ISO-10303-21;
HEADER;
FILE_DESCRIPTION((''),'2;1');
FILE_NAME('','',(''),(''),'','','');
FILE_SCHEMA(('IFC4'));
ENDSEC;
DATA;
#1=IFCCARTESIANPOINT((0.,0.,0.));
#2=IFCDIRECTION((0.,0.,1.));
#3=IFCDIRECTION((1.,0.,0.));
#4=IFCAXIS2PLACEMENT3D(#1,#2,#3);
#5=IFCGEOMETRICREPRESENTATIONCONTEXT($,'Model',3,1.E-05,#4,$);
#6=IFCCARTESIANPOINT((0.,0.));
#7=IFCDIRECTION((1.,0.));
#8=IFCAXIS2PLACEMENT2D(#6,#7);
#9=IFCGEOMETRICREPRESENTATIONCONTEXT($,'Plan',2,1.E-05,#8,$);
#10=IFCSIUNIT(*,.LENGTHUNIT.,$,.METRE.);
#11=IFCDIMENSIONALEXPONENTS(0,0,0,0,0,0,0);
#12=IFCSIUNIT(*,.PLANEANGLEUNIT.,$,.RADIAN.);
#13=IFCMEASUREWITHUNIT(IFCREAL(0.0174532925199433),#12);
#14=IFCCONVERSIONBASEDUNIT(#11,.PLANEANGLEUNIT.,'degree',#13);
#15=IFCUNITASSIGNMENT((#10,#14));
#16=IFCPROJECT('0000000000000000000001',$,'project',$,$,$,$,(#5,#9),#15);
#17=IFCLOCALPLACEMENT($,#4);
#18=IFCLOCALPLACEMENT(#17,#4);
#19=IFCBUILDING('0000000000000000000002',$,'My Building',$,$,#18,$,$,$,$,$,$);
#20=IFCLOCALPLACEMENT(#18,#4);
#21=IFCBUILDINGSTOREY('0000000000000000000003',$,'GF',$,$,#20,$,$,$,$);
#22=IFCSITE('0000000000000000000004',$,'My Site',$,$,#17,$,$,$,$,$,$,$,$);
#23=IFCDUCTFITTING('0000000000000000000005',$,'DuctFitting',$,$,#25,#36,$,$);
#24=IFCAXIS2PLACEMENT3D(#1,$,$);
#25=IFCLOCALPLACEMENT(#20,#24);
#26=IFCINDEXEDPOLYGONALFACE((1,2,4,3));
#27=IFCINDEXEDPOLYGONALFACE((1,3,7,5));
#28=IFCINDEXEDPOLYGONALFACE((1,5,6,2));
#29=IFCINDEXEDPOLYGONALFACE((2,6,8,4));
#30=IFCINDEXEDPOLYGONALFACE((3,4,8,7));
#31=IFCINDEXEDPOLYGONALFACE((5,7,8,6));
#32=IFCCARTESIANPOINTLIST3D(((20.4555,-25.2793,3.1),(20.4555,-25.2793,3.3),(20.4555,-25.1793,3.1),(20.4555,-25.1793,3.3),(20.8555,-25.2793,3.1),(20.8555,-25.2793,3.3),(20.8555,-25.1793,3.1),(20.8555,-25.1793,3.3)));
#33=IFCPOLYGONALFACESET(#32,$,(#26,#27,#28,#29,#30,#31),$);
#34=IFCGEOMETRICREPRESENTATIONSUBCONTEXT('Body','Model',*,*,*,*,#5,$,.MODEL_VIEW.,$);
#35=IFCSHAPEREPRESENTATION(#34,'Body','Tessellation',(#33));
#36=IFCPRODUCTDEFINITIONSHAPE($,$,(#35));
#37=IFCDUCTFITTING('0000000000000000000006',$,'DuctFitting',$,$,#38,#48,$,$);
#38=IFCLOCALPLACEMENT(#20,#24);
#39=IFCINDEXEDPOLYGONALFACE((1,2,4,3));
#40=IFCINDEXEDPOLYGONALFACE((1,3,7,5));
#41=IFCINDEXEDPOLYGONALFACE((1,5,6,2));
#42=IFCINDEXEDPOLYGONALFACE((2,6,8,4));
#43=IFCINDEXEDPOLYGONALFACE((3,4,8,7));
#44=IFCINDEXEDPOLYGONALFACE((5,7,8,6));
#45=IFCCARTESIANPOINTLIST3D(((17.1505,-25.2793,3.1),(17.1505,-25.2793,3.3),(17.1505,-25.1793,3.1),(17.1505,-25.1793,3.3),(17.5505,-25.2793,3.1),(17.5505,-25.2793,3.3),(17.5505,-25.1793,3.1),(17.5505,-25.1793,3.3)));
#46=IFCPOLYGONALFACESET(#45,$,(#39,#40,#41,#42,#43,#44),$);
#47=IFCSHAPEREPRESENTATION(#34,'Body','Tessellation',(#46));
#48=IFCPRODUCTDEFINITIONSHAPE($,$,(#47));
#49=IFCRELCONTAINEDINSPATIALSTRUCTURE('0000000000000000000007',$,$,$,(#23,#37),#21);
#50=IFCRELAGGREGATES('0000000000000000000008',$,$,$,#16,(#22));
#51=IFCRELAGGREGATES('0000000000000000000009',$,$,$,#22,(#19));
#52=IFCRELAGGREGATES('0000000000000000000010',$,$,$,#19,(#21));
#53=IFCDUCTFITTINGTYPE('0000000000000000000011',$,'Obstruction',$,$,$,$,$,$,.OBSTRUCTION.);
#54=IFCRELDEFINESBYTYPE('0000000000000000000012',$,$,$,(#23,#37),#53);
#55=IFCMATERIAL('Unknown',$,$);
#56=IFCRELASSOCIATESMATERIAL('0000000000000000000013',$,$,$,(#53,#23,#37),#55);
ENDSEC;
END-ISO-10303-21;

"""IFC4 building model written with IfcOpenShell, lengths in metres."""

from ifc_helpers import new_model, entity, si_unit, converted_unit, frame, origin_with_axes, origin_2d_with_axis, place, context, subcontext, project, spatial, rectangle, extrude, material, material_profile, profile_set, profile_usage, type_object, element, save


model = new_model("IFC4")

# Units and contexts
model_context = context("Model", 3, precision=1e-05, world=origin_with_axes())
plan_context = context("Plan", 2, precision=1e-05, world=origin_2d_with_axis())
body_context_1 = subcontext(model_context, "Body", "Model", "MODEL_VIEW")
ifc_project = project(units=[si_unit("LENGTHUNIT", "METRE"), converted_unit("PLANEANGLEUNIT", "degree", entity("IfcReal", 0.0174532925199433), si_unit("PLANEANGLEUNIT", "RADIAN"), dimensions=[0, 0, 0, 0, 0, 0, 0])], contexts=[model_context, plan_context])

# Site, building, storey
site_placement = place(None, origin_with_axes())
site = spatial("IfcSite", under=ifc_project, at=site_placement, Name="My Site")
building_placement = place(site_placement, origin_with_axes())
building = spatial("IfcBuilding", under=site, at=building_placement, Name="My Building")
storey_placement = place(building_placement, origin_with_axes())
storey = spatial("IfcBuildingStorey", under=building, at=storey_placement, Name="GF")

# Shared definitions
ifc_material = material(Name="Unknown")

# Duct fittings
ifc_material_profile_1 = material_profile(ifc_material, rectangle(XDim=0.4, YDim=0.2))
ifc_profile_set_1 = profile_set([ifc_material_profile_1])
duct_fitting_type = type_object("IfcDuctFittingType", Name="Obstruction", PredefinedType="OBSTRUCTION", material=ifc_profile_set_1)
ifc_profile_usage_1 = profile_usage(ifc_profile_set_1, cardinal=5)
duct_fitting_1_placement = place(storey_placement, frame((20.6555, -25.1793, 3.2), z_axis=(0.0, -1.0, 0.0), x_axis=(1.0, 0.0, 0.0)))
element("IfcDuctFitting", 1, at=duct_fitting_1_placement, inside=storey, type_object=duct_fitting_type, material=ifc_profile_usage_1, Name="DuctFitting", context=body_context_1, shape_type="SweptSolid", body=[
    extrude(rectangle(XDim=0.4, YDim=0.2), origin_with_axes(), (0.0, 0.0, 1.0), 0.1),
])
ifc_profile_usage_2 = profile_usage(ifc_profile_set_1, cardinal=5)
duct_fitting_2_placement = place(storey_placement, frame((17.3505, -25.1793, 3.2), z_axis=(0.0, -1.0, 0.0), x_axis=(1.0, 0.0, 0.0)))
element("IfcDuctFitting", 2, at=duct_fitting_2_placement, inside=storey, type_object=duct_fitting_type, material=ifc_profile_usage_2, Name="DuctFitting", context=body_context_1, shape_type="SweptSolid", body=[
    extrude(rectangle(XDim=0.4, YDim=0.2), origin_with_axes(), (0.0, 0.0, 1.0), 0.1),
])

save(model, "model.ifc")
